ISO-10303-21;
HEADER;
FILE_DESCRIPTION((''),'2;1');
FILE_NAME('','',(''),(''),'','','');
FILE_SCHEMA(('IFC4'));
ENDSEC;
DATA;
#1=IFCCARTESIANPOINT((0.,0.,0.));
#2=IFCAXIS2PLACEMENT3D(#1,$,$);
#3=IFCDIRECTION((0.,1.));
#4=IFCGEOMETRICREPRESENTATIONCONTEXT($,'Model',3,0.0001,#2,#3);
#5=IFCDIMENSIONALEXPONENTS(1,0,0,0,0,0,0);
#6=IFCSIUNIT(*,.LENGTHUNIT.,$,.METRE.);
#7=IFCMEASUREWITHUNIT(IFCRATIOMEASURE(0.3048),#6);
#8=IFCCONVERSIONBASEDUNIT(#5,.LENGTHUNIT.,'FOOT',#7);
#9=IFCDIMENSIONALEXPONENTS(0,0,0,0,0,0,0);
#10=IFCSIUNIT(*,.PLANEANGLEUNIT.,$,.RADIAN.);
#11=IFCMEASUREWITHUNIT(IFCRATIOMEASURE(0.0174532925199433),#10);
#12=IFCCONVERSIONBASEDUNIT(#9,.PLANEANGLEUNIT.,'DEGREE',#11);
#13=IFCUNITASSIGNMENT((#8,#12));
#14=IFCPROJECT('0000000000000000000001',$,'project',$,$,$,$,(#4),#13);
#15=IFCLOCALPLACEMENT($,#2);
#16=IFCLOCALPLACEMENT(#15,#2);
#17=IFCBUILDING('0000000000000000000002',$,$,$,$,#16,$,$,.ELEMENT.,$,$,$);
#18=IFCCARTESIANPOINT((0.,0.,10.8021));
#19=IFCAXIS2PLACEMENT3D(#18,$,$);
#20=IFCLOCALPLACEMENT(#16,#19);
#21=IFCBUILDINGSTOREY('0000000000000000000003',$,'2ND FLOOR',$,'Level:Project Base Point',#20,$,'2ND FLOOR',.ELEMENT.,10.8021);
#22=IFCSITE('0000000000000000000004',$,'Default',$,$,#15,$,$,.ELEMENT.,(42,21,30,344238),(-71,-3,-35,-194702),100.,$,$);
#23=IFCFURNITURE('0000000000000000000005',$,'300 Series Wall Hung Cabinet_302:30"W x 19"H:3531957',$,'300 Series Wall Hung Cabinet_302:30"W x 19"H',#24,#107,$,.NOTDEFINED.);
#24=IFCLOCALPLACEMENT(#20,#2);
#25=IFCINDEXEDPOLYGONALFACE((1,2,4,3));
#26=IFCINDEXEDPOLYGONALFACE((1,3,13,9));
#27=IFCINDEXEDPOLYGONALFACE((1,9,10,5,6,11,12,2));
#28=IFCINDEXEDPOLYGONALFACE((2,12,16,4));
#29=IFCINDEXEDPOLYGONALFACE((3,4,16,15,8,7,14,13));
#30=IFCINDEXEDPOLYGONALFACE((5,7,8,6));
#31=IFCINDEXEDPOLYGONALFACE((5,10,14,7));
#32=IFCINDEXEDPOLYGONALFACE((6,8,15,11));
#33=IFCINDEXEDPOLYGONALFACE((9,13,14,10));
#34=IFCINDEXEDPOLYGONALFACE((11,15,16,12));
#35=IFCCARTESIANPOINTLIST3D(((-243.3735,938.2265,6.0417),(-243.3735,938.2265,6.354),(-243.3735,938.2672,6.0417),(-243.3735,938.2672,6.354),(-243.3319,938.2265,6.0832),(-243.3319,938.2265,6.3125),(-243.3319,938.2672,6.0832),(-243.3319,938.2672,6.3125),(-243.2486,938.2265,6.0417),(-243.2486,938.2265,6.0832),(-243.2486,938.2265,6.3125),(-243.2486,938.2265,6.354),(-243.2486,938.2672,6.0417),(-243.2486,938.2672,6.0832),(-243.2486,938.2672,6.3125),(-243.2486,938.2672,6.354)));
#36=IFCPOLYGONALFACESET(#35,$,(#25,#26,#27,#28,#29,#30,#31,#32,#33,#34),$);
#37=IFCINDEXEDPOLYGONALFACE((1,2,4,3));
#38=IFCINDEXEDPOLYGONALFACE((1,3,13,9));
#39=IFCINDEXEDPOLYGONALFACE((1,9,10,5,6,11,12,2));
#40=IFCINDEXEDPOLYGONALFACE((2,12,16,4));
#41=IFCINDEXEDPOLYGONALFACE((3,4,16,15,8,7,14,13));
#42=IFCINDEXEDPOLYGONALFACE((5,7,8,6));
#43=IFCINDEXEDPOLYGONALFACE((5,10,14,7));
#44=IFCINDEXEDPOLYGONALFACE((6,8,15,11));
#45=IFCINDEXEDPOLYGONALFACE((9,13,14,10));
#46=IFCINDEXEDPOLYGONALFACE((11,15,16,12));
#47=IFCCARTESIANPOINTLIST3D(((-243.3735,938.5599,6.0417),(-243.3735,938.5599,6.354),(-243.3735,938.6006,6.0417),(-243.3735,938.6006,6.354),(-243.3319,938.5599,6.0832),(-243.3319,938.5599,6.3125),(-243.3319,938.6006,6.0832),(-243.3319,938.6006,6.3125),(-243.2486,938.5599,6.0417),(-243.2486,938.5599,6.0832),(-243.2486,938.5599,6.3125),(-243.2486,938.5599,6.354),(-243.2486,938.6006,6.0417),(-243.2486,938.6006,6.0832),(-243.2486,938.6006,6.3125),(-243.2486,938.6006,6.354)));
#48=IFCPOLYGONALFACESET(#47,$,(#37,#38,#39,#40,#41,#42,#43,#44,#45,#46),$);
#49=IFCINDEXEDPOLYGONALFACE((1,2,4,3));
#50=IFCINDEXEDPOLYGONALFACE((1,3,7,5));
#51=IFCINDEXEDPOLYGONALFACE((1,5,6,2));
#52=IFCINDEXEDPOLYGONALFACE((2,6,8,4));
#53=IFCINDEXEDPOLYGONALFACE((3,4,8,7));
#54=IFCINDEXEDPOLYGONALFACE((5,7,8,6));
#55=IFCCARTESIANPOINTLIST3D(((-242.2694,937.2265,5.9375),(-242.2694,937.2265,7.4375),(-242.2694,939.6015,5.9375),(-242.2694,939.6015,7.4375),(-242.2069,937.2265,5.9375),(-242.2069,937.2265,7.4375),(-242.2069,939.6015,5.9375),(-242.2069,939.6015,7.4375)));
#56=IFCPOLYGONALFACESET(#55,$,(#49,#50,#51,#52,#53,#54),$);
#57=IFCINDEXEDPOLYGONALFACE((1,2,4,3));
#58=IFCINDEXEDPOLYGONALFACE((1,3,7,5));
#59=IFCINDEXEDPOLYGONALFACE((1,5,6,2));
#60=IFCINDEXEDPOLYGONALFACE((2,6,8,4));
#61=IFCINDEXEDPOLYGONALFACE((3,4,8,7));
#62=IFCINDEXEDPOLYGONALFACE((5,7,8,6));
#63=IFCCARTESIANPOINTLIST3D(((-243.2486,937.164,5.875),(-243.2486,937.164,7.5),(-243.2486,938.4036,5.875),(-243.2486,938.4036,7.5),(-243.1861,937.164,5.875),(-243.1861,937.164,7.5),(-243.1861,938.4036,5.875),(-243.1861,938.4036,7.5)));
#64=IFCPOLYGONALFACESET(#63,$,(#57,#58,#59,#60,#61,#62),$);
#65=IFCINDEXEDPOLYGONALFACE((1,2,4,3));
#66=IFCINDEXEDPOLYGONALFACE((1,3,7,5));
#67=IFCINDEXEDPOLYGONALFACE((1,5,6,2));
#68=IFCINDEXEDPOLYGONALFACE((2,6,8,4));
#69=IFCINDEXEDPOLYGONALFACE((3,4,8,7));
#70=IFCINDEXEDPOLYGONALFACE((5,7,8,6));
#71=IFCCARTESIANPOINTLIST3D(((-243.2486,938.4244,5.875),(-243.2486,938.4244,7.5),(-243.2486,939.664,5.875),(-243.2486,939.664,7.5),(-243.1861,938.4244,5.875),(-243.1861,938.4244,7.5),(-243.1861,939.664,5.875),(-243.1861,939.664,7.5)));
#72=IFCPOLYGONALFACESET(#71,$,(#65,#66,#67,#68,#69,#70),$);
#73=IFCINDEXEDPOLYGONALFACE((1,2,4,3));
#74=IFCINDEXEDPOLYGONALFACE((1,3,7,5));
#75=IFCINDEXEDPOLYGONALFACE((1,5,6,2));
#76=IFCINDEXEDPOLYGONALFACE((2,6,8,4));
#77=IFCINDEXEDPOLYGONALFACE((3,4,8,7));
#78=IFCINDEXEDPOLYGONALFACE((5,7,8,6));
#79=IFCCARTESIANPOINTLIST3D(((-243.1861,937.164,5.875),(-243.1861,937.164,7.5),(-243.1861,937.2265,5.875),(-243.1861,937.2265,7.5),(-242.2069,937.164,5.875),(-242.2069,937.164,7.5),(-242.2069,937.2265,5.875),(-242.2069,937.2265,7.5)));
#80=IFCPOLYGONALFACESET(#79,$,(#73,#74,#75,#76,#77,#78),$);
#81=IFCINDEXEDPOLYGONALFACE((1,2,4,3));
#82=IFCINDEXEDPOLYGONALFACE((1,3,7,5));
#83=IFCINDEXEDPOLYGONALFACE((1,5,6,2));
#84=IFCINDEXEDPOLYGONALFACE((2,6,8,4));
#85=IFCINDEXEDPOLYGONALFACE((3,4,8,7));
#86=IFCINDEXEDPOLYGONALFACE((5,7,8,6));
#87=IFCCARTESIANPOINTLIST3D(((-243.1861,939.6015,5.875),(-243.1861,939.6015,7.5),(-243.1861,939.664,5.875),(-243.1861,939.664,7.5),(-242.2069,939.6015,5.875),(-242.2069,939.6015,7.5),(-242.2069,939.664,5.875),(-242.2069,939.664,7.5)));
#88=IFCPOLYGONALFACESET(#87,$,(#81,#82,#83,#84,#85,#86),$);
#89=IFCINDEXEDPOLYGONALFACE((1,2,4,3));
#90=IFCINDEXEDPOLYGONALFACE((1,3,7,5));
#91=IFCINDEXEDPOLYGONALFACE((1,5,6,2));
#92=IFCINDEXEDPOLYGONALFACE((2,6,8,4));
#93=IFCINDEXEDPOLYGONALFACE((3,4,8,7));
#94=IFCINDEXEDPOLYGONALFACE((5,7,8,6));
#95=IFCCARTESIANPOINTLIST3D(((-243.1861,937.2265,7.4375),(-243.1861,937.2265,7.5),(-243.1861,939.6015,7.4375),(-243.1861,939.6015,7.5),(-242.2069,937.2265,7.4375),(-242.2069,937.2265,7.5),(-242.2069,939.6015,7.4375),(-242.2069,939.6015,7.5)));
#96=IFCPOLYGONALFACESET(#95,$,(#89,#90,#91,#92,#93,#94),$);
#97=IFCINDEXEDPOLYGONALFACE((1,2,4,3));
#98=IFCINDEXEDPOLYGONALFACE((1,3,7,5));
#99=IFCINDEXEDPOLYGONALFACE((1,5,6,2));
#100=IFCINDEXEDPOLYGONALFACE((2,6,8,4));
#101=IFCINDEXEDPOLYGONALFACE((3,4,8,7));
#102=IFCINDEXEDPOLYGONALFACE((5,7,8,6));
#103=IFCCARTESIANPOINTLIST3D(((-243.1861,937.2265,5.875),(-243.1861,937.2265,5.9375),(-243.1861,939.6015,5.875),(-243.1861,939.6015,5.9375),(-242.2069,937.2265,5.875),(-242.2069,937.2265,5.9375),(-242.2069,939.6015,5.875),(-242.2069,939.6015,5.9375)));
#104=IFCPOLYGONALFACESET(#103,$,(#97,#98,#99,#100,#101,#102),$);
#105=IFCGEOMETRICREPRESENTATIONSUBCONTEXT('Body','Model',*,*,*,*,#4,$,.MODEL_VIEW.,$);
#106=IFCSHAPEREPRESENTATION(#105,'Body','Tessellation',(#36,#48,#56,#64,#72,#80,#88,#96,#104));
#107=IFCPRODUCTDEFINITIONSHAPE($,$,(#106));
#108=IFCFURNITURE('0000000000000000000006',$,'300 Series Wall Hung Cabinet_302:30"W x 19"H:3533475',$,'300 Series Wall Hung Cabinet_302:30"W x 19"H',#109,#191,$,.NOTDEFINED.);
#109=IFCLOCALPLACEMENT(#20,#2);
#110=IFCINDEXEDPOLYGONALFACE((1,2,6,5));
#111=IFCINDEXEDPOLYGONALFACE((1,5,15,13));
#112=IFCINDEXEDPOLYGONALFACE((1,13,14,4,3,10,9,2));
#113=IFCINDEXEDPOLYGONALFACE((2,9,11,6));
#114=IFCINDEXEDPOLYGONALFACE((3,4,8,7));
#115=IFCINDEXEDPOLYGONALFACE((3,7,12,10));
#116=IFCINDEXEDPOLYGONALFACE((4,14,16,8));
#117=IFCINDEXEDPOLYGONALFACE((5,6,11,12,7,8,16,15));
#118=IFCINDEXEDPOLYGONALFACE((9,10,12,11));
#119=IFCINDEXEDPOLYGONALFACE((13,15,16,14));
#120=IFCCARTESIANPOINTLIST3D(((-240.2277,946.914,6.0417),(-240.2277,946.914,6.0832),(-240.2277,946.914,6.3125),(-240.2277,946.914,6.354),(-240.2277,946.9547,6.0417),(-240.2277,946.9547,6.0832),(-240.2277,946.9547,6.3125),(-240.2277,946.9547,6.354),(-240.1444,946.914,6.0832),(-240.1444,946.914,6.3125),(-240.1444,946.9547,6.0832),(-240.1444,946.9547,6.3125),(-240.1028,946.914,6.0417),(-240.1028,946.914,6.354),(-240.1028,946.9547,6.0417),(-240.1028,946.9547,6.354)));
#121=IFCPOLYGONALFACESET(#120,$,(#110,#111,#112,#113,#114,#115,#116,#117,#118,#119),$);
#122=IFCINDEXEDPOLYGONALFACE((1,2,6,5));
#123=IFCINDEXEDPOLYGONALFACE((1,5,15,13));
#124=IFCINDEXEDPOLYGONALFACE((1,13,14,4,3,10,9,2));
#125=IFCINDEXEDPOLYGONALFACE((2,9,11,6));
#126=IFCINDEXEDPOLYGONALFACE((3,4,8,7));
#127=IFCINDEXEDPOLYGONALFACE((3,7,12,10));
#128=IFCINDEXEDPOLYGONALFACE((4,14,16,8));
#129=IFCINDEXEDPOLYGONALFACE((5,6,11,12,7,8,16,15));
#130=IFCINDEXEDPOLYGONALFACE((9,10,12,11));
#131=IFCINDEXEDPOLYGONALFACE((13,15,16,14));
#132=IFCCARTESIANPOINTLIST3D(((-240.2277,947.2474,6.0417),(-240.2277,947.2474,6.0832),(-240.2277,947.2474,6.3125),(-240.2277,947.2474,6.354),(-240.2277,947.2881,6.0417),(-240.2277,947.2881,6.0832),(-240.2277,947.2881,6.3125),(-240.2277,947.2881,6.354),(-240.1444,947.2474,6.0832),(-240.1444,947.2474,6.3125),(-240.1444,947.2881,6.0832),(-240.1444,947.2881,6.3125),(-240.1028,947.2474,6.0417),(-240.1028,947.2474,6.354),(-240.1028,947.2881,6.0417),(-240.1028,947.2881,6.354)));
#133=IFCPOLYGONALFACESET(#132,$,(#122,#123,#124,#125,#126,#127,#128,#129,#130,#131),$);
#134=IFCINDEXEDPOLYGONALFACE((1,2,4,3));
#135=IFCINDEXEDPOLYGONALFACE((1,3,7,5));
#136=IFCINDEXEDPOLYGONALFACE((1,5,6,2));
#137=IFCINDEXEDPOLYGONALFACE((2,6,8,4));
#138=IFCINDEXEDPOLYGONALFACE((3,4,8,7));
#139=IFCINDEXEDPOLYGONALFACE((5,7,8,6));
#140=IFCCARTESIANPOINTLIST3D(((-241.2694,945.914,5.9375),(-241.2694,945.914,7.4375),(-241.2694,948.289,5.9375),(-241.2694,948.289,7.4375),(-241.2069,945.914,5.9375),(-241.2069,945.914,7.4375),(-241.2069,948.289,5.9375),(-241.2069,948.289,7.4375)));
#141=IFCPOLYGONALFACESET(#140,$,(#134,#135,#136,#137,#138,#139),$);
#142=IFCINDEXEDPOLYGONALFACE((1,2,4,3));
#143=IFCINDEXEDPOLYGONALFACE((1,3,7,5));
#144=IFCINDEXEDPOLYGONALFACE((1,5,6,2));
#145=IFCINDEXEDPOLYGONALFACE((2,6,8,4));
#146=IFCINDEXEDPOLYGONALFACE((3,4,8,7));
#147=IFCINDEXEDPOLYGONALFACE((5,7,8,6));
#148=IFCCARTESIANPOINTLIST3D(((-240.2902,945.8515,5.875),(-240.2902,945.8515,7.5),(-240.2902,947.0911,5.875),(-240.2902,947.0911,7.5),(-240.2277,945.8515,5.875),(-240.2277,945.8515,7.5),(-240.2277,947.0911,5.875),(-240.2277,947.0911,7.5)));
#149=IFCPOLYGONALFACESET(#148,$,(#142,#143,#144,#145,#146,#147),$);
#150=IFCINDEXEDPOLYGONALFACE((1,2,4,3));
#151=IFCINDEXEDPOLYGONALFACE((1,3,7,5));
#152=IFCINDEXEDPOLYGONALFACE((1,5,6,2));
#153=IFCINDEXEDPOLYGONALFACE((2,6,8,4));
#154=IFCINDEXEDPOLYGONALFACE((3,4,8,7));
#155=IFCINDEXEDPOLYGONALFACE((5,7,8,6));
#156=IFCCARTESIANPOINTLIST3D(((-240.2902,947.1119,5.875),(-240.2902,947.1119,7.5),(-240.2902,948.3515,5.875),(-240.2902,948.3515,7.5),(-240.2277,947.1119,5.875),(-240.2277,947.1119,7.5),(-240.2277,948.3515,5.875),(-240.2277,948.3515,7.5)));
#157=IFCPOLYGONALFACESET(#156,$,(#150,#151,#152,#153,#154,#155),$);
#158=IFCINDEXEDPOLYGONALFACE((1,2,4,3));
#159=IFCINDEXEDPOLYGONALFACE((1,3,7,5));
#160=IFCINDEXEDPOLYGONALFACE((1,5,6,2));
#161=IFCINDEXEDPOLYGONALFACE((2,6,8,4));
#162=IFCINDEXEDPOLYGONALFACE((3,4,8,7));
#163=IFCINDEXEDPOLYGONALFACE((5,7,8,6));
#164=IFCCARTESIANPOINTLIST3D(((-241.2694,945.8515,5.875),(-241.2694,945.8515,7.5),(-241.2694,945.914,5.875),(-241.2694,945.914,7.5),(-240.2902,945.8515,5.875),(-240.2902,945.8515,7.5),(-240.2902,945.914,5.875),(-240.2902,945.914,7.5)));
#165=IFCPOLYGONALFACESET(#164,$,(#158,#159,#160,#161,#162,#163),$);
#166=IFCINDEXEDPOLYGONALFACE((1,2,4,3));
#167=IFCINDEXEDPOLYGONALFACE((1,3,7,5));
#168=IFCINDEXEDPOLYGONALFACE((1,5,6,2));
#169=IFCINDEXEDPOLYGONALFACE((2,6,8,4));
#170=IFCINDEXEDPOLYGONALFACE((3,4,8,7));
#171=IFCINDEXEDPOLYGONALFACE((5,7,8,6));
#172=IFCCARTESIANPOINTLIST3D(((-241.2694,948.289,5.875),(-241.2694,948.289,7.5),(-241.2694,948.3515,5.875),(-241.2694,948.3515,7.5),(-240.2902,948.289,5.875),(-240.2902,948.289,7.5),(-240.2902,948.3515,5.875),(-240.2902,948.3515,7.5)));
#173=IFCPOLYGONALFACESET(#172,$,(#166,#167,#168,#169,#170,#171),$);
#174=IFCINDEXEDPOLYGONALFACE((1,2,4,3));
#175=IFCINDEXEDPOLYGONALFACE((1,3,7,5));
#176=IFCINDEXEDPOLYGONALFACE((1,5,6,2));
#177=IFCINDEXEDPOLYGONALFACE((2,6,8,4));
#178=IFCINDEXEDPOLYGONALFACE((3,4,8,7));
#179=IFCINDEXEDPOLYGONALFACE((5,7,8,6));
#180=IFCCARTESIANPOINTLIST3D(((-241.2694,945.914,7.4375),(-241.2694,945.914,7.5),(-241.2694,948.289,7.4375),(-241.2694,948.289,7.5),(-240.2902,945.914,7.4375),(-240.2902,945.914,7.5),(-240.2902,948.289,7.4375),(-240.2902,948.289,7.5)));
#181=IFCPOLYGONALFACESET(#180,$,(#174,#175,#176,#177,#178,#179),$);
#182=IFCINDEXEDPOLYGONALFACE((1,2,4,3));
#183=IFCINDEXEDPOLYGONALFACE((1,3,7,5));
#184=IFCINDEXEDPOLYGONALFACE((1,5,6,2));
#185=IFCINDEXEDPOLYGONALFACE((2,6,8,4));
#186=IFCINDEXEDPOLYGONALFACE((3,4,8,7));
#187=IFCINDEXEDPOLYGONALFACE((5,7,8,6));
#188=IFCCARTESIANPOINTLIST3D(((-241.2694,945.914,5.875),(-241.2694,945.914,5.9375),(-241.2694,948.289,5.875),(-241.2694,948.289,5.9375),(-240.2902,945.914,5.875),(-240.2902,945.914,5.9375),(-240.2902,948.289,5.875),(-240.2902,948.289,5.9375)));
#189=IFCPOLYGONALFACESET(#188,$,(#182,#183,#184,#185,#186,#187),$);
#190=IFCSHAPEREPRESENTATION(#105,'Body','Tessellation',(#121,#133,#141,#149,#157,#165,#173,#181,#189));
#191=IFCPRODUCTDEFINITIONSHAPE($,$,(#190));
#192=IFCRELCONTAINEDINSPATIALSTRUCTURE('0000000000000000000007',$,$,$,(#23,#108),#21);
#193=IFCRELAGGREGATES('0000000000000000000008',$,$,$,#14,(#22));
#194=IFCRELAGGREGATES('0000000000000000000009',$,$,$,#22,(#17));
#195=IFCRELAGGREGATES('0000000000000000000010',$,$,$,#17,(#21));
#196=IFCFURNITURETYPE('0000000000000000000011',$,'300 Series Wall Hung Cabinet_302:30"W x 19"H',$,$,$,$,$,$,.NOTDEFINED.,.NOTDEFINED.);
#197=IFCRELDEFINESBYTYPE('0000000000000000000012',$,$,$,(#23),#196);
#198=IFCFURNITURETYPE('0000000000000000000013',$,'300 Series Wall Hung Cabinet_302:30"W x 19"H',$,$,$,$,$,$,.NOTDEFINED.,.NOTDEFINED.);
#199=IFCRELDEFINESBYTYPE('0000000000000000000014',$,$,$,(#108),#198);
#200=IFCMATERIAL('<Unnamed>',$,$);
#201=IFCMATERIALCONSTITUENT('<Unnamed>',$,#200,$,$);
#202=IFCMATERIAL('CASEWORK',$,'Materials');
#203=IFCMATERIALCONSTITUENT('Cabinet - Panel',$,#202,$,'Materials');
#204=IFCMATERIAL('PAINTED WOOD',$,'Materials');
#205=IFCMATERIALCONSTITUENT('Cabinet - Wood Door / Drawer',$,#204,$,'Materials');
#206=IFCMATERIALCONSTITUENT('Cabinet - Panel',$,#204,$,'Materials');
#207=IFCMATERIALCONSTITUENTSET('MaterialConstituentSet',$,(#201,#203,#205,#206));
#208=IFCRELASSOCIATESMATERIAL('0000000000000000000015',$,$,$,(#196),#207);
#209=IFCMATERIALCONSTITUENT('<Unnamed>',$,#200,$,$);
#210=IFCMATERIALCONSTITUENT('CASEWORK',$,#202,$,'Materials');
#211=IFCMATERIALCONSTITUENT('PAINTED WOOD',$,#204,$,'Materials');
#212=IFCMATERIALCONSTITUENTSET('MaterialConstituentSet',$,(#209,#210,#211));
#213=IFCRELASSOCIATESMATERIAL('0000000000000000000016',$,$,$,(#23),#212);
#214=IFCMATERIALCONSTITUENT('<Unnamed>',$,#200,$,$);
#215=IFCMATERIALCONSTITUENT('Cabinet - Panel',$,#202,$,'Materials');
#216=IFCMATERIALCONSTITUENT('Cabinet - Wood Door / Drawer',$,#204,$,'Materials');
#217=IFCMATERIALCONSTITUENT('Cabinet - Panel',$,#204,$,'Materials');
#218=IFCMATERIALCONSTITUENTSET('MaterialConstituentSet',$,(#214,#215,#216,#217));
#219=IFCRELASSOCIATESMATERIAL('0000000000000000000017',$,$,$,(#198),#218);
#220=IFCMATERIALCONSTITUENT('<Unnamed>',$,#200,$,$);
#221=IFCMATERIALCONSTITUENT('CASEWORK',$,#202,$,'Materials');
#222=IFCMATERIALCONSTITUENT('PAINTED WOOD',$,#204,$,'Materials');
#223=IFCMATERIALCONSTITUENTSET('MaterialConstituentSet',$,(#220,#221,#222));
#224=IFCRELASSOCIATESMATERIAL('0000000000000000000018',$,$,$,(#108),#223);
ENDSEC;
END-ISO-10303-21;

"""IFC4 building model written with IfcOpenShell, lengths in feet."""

from ifc_helpers import new_model, entity, si_unit, converted_unit, direction, frame, frame_2d, origin, origin_2d_with_axis, place, context, subcontext, project, spatial, polyline, rectangle, outline, extrude, source, transform, mapped, material, constituent, constituent_set, type_object, type_shapes, element, save


model = new_model("IFC4")

# Units and contexts
model_context = context("Model", 3, precision=0.0001, world=origin(), true_north=direction((0.0, 1.0)))
body_context = subcontext(model_context, "Body", "Model", "MODEL_VIEW")
ifc_project = project(units=[converted_unit("LENGTHUNIT", "FOOT", entity("IfcRatioMeasure", 0.3048), si_unit("LENGTHUNIT", "METRE"), dimensions=[1, 0, 0, 0, 0, 0, 0]), converted_unit("PLANEANGLEUNIT", "DEGREE", entity("IfcRatioMeasure", 0.0174532925199433), si_unit("PLANEANGLEUNIT", "RADIAN"), dimensions=[0, 0, 0, 0, 0, 0, 0])], contexts=[model_context])

# Site, building, storey
site_placement = place(None, origin())
site = spatial("IfcSite", under=ifc_project, at=site_placement, Name="Default", CompositionType="ELEMENT", RefLatitude=(42, 21, 30, 344238), RefLongitude=(-71, -3, -35, -194702), RefElevation=100.0)
building_placement = place(site_placement, origin())
building = spatial("IfcBuilding", under=site, at=building_placement, CompositionType="ELEMENT")
storey_placement = place(building_placement, frame((0.0, 0.0, 10.8021)))
storey = spatial("IfcBuildingStorey", under=building, at=storey_placement, Name="2ND FLOOR", ObjectType="Level:Project Base Point", LongName="2ND FLOOR", CompositionType="ELEMENT", Elevation=10.8021)

# Furniture
ifc_material_1 = material(Name="CASEWORK", Category="Materials")
ifc_material_2 = material(Name="<Unnamed>")
ifc_material_3 = material(Name="PAINTED WOOD", Category="Materials")
ifc_constituent_1 = constituent(ifc_material_2, Name="<Unnamed>")
ifc_constituent_2 = constituent(ifc_material_1, Name="CASEWORK", Category="Materials")
ifc_constituent_3 = constituent(ifc_material_3, Name="PAINTED WOOD", Category="Materials")
ifc_constituent_set_1 = constituent_set(constituents=[ifc_constituent_1, ifc_constituent_2, ifc_constituent_3], Name="MaterialConstituentSet")
ifc_constituent_4 = constituent(ifc_material_2, Name="<Unnamed>")
ifc_constituent_5 = constituent(ifc_material_1, Name="Cabinet - Panel", Category="Materials")
ifc_constituent_6 = constituent(ifc_material_3, Name="Cabinet - Wood Door / Drawer", Category="Materials")
ifc_constituent_7 = constituent(ifc_material_3, Name="Cabinet - Panel", Category="Materials")
ifc_constituent_set_2 = constituent_set(constituents=[ifc_constituent_4, ifc_constituent_5, ifc_constituent_6, ifc_constituent_7], Name="MaterialConstituentSet")
furniture_type_1 = type_object("IfcFurnitureType", Name="300 Series Wall Hung Cabinet_302:30\"W x 19\"H", AssemblyPlace="NOTDEFINED", PredefinedType="NOTDEFINED", material=ifc_constituent_set_2)
shared_shape_1 = source(origin(), body_context, "Body", "SweptSolid", [
    extrude(outline(polyline([(-0.0521, -0.1146), (-0.0521, -0.1562), (0.0729, -0.1562), (0.0729, 0.1562), (-0.0521, 0.1562), (-0.0521, 0.1146), (0.0313, 0.1146), (0.0313, -0.1146), (-0.0521, -0.1146)])), frame((1.0625, 1.0937, 0.3229), z_axis=(-1.0, 0.0, 0.0), x_axis=(0.0, 1.0, 0.0)), (0.0, 0.0, -1.0), 0.0407),
    extrude(outline(polyline([(-0.0521, -0.1146), (-0.0521, -0.1562), (0.0729, -0.1562), (0.0729, 0.1562), (-0.0521, 0.1562), (-0.0521, 0.1146), (0.0313, 0.1146), (0.0313, -0.1146), (-0.0521, -0.1146)])), frame((1.3958, 1.0937, 0.3229), z_axis=(-1.0, 0.0, 0.0), x_axis=(0.0, 1.0, 0.0)), (0.0, 0.0, -1.0), 0.0407),
    extrude(rectangle(XDim=0.0625, YDim=2.375, at=frame_2d((0.0, 0.0), x_axis=(1.0, 0.0))), frame((1.25, 0.0313, 0.0625), z_axis=(0.0, 0.0, 1.0), x_axis=(0.0, 1.0, 0.0)), (0.0, 0.0, 1.0), 1.5),
    extrude(rectangle(XDim=0.0625, YDim=1.2396, at=origin_2d_with_axis()), frame((0.6198, 1.0104, 0.0), z_axis=(0.0, 0.0, 1.0), x_axis=(0.0, 1.0, 0.0)), (0.0, 0.0, 1.0), 1.625),
    extrude(rectangle(XDim=0.0625, YDim=1.2396, at=frame_2d((0.0, 0.0), x_axis=(1.0, 0.0))), frame((1.8802, 1.0104, 0.0), z_axis=(0.0, 0.0, 1.0), x_axis=(0.0, 1.0, 0.0)), (0.0, 0.0, 1.0), 1.625),
    extrude(rectangle(XDim=0.0625, YDim=0.9792, at=frame_2d((0.0, 0.0), x_axis=(1.0, 0.0))), frame((0.0313, 0.4896, 0.0)), (0.0, 0.0, 1.0), 1.625),
    extrude(rectangle(XDim=0.0625, YDim=0.9792, at=frame_2d((0.0, 0.0), x_axis=(1.0, 0.0))), frame((2.4688, 0.4896, 0.0)), (0.0, 0.0, 1.0), 1.625),
    extrude(rectangle(XDim=2.375, YDim=0.9792, at=frame_2d((0.0, 0.0), x_axis=(1.0, 0.0))), frame((1.25, 0.4896, 1.5625), z_axis=(0.0, 0.0, 1.0), x_axis=(-1.0, 0.0, 0.0)), (0.0, 0.0, 1.0), 0.0625),
    extrude(rectangle(XDim=2.375, YDim=0.9792, at=frame_2d((0.0, 0.0), x_axis=(1.0, 0.0))), frame((1.25, 0.4896, 0.0), z_axis=(0.0, 0.0, 1.0), x_axis=(-1.0, 0.0, 0.0)), (0.0, 0.0, 1.0), 0.0625),
])
type_shapes(furniture_type_1, [shared_shape_1])
furniture_1_placement = place(storey_placement, frame((-242.2069, 937.164, 5.875), z_axis=(0.0, 0.0, 1.0), x_axis=(0.0, 1.0, 0.0)))
element("IfcFurniture", 1, at=furniture_1_placement, inside=storey, type_object=furniture_type_1, material=ifc_constituent_set_1, Name="300 Series Wall Hung Cabinet_302:30\"W x 19\"H:3531957", ObjectType="300 Series Wall Hung Cabinet_302:30\"W x 19\"H", PredefinedType="NOTDEFINED", context=body_context, shape_type="MappedRepresentation", body=[
    mapped(shared_shape_1, transform((0.0, 0.0, 0.0), scale=1.0)),
])
ifc_constituent_8 = constituent(ifc_material_2, Name="<Unnamed>")
ifc_constituent_9 = constituent(ifc_material_1, Name="CASEWORK", Category="Materials")
ifc_constituent_10 = constituent(ifc_material_3, Name="PAINTED WOOD", Category="Materials")
ifc_constituent_set_3 = constituent_set(constituents=[ifc_constituent_8, ifc_constituent_9, ifc_constituent_10], Name="MaterialConstituentSet")
ifc_constituent_11 = constituent(ifc_material_2, Name="<Unnamed>")
ifc_constituent_12 = constituent(ifc_material_1, Name="Cabinet - Panel", Category="Materials")
ifc_constituent_13 = constituent(ifc_material_3, Name="Cabinet - Wood Door / Drawer", Category="Materials")
ifc_constituent_14 = constituent(ifc_material_3, Name="Cabinet - Panel", Category="Materials")
ifc_constituent_set_4 = constituent_set(constituents=[ifc_constituent_11, ifc_constituent_12, ifc_constituent_13, ifc_constituent_14], Name="MaterialConstituentSet")
furniture_type_2 = type_object("IfcFurnitureType", Name="300 Series Wall Hung Cabinet_302:30\"W x 19\"H", AssemblyPlace="NOTDEFINED", PredefinedType="NOTDEFINED", material=ifc_constituent_set_4)
shared_shape_2 = source(origin(), body_context, "Body", "SweptSolid", [
    extrude(outline(polyline([(0.1146, -0.0521), (0.1562, -0.0521), (0.1562, 0.0729), (-0.1562, 0.0729), (-0.1562, -0.0521), (-0.1146, -0.0521), (-0.1146, 0.0313), (0.1146, 0.0313), (0.1146, -0.0521)])), frame((1.0625, 0.0729, 0.3229), z_axis=(1.0, 0.0, 0.0), x_axis=(0.0, 0.0, 1.0)), (0.0, 0.0, 1.0), 0.0407),
    extrude(outline(polyline([(0.1146, -0.0521), (0.1562, -0.0521), (0.1562, 0.0729), (-0.1562, 0.0729), (-0.1562, -0.0521), (-0.1146, -0.0521), (-0.1146, 0.0313), (0.1146, 0.0313), (0.1146, -0.0521)])), frame((1.3958, 0.0729, 0.3229), z_axis=(1.0, 0.0, 0.0), x_axis=(0.0, 0.0, 1.0)), (0.0, 0.0, 1.0), 0.0407),
    extrude(rectangle(XDim=2.375, YDim=0.0625, at=origin_2d_with_axis()), frame((1.25, 1.1354, 0.0625), z_axis=(0.0, 0.0, 1.0), x_axis=(-1.0, 0.0, 0.0)), (0.0, 0.0, 1.0), 1.5),
    extrude(rectangle(XDim=1.2396, YDim=0.0625, at=origin_2d_with_axis()), frame((0.6198, 0.1562, 0.0), z_axis=(0.0, 0.0, 1.0), x_axis=(-1.0, 0.0, 0.0)), (0.0, 0.0, 1.0), 1.625),
    extrude(rectangle(XDim=1.2396, YDim=0.0625, at=frame_2d((0.0, 0.0), x_axis=(1.0, 0.0))), frame((1.8802, 0.1562, 0.0), z_axis=(0.0, 0.0, 1.0), x_axis=(-1.0, 0.0, 0.0)), (0.0, 0.0, 1.0), 1.625),
    extrude(rectangle(XDim=0.9792, YDim=0.0625, at=frame_2d((0.0, 0.0), x_axis=(1.0, 0.0))), frame((0.0313, 0.677, 0.0), z_axis=(0.0, 0.0, 1.0), x_axis=(0.0, -1.0, 0.0)), (0.0, 0.0, 1.0), 1.625),
    extrude(rectangle(XDim=0.9792, YDim=0.0625, at=frame_2d((0.0, 0.0), x_axis=(1.0, 0.0))), frame((2.4688, 0.677, 0.0), z_axis=(0.0, 0.0, 1.0), x_axis=(0.0, -1.0, 0.0)), (0.0, 0.0, 1.0), 1.625),
    extrude(rectangle(XDim=0.9792, YDim=2.375, at=frame_2d((0.0, 0.0), x_axis=(1.0, 0.0))), frame((1.25, 0.677, 1.5625), z_axis=(0.0, 0.0, 1.0), x_axis=(0.0, 1.0, 0.0)), (0.0, 0.0, 1.0), 0.0625),
    extrude(rectangle(XDim=0.9792, YDim=2.375, at=frame_2d((0.0, 0.0), x_axis=(1.0, 0.0))), frame((1.25, 0.677, 0.0), z_axis=(0.0, 0.0, 1.0), x_axis=(0.0, 1.0, 0.0)), (0.0, 0.0, 1.0), 0.0625),
])
type_shapes(furniture_type_2, [shared_shape_2])
furniture_2_placement = place(storey_placement, frame((-240.1028, 945.8515, 5.875), z_axis=(0.0, 0.0, 1.0), x_axis=(0.0, 1.0, 0.0)))
element("IfcFurniture", 2, at=furniture_2_placement, inside=storey, type_object=furniture_type_2, material=ifc_constituent_set_3, Name="300 Series Wall Hung Cabinet_302:30\"W x 19\"H:3533475", ObjectType="300 Series Wall Hung Cabinet_302:30\"W x 19\"H", PredefinedType="NOTDEFINED", context=body_context, shape_type="MappedRepresentation", body=[
    mapped(shared_shape_2, transform((0.0, 0.0, 0.0), scale=1.0)),
])

save(model, "model.ifc")
